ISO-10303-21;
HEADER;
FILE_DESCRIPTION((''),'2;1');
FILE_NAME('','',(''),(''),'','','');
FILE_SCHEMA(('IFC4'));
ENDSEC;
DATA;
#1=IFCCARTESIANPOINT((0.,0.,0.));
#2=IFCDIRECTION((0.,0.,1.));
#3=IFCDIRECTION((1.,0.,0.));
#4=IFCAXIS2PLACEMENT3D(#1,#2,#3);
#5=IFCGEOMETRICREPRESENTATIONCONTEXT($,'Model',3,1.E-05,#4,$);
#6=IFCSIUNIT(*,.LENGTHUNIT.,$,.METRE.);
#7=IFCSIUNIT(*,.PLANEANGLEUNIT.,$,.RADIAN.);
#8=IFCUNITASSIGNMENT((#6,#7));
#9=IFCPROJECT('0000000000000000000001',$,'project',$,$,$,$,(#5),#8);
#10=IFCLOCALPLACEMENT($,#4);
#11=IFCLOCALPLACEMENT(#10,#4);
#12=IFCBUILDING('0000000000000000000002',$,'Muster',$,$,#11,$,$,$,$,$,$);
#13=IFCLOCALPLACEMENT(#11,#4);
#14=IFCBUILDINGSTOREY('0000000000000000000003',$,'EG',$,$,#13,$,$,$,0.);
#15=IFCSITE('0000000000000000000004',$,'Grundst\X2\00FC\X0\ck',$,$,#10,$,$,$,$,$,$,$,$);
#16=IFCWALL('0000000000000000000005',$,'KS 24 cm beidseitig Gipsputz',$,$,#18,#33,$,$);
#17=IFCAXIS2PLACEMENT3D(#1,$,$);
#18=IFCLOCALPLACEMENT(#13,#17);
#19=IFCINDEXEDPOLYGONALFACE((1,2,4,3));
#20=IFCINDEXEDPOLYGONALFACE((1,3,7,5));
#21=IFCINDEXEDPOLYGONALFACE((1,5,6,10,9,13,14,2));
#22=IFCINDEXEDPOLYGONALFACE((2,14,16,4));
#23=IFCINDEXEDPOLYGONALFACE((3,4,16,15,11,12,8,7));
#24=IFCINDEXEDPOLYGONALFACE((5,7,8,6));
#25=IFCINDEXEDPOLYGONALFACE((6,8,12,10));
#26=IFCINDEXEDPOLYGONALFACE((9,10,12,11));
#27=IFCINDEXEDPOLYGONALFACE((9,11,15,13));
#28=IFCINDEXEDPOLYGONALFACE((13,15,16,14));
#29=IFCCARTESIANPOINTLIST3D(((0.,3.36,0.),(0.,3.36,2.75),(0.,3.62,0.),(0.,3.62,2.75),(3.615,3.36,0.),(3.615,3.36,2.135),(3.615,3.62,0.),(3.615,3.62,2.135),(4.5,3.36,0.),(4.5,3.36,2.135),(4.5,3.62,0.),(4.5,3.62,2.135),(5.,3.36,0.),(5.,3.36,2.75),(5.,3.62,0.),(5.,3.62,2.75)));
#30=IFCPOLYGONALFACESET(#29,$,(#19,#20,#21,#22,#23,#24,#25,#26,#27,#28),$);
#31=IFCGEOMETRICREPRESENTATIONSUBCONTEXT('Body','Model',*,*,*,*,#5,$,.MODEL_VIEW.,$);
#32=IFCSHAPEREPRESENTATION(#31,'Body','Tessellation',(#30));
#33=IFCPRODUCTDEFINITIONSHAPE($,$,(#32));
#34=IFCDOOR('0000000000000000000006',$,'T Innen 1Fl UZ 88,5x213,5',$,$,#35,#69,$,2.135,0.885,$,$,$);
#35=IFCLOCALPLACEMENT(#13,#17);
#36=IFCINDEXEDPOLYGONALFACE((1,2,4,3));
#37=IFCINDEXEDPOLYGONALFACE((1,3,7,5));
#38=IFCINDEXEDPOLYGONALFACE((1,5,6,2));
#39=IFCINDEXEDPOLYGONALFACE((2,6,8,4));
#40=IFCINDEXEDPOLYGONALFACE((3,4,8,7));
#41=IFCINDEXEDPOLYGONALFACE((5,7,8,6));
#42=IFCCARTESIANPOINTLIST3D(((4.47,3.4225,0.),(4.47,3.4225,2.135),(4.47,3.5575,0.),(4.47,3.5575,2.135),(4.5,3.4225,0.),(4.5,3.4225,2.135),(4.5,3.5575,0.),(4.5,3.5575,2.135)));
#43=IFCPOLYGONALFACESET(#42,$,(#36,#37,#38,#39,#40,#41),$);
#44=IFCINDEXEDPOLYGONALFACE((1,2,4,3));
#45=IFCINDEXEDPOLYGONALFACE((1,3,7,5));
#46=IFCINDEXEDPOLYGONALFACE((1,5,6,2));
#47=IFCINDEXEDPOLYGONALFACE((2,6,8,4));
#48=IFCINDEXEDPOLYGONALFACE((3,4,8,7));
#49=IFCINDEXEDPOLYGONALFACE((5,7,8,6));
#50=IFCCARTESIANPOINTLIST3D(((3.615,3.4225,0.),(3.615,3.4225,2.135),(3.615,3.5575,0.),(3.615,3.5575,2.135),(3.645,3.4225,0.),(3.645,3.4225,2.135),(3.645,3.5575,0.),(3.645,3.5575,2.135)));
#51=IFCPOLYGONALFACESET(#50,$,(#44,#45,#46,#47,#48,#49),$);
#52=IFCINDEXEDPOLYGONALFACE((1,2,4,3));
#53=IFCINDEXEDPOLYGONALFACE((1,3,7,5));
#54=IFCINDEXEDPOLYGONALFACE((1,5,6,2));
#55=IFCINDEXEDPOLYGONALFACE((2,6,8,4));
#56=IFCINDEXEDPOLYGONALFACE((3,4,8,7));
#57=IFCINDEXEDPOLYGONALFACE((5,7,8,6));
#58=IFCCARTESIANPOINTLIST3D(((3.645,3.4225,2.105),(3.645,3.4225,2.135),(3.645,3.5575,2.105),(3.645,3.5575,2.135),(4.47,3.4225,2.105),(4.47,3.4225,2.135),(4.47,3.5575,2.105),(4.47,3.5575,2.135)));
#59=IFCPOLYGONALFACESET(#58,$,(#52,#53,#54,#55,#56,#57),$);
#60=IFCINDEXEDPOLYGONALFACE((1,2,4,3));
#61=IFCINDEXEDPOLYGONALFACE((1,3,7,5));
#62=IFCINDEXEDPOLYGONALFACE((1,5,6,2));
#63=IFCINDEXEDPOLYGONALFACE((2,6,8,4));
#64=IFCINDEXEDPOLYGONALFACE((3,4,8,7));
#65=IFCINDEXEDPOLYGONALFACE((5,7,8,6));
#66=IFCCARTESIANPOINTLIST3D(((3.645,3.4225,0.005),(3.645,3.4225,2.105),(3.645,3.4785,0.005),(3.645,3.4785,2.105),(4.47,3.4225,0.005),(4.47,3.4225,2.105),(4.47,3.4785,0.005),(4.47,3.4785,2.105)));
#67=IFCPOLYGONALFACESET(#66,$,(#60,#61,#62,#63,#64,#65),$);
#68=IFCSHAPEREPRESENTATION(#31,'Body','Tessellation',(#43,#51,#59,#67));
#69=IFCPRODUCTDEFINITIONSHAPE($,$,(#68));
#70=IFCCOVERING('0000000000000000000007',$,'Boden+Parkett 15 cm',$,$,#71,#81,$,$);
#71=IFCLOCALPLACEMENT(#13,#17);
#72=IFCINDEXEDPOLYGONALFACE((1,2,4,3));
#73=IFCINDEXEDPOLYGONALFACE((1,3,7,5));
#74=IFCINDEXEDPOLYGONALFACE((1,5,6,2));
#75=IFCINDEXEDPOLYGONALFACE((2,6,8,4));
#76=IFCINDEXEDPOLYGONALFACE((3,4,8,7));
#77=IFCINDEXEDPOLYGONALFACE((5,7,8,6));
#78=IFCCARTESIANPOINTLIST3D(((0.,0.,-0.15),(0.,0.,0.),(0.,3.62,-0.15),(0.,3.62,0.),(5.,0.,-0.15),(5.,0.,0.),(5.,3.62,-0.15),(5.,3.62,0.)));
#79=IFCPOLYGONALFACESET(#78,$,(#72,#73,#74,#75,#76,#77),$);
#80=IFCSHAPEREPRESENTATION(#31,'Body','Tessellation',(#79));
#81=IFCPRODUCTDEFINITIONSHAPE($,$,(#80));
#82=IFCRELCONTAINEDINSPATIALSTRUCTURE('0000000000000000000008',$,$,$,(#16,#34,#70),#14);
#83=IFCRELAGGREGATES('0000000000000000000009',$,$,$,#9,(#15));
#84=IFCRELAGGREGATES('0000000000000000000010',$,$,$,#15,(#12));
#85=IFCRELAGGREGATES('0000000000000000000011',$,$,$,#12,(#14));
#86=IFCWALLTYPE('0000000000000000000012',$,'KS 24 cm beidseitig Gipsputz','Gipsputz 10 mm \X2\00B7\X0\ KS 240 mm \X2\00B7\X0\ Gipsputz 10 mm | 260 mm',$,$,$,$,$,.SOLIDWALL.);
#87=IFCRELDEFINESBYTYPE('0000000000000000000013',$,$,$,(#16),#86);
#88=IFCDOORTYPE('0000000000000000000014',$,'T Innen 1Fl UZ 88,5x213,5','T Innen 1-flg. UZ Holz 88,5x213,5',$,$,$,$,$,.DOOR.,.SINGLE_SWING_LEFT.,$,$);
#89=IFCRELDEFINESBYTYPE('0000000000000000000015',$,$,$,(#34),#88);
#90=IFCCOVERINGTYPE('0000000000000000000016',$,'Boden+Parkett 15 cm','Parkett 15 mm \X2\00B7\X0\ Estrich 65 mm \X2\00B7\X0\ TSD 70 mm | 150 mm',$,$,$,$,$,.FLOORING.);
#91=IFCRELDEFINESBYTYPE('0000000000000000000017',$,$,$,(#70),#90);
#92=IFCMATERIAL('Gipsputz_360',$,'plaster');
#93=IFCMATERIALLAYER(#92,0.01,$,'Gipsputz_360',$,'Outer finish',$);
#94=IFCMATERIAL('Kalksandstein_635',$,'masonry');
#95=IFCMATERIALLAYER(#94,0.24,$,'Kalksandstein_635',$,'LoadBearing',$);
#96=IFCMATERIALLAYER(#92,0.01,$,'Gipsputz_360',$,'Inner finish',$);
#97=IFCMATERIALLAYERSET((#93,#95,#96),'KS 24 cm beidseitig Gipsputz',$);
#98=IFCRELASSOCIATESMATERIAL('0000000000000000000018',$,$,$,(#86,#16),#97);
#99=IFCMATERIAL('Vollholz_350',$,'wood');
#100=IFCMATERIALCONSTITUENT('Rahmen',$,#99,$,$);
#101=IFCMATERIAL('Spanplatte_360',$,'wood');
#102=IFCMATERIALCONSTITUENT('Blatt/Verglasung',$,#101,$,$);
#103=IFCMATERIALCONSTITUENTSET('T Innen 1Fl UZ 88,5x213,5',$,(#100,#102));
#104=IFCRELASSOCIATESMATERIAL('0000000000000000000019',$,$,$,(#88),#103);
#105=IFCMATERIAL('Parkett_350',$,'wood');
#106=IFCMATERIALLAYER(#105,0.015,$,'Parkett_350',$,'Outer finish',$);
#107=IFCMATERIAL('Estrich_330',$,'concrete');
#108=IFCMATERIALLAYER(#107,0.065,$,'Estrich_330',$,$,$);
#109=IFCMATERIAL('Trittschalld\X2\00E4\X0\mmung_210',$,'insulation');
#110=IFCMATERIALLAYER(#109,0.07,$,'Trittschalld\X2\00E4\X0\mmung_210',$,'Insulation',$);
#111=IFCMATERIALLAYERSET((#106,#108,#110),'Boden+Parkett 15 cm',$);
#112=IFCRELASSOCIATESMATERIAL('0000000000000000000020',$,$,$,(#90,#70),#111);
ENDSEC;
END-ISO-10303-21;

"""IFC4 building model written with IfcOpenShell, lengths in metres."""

from ifc_helpers import new_model, si_unit, frame, frame_2d, origin, origin_with_axes, place, context, subcontext, project, spatial, rectangle, extrude, source, transform, mapped, material, layer, layer_set, layer_usage, constituent, constituent_set, type_object, type_shapes, element, fill, save


model = new_model("IFC4")

# Units and contexts
model_context = context("Model", 3, precision=1e-05, world=origin_with_axes())
body_context = subcontext(model_context, "Body", "Model", "MODEL_VIEW")
ifc_project = project(units=[si_unit("LENGTHUNIT", "METRE"), si_unit("PLANEANGLEUNIT", "RADIAN")], contexts=[model_context])

# Site, building, storey
site_placement = place(None, origin_with_axes())
site = spatial("IfcSite", under=ifc_project, at=site_placement, Name="Grundstück")
building_placement = place(site_placement, origin_with_axes())
building = spatial("IfcBuilding", under=site, at=building_placement, Name="Muster")
storey_placement = place(building_placement, origin_with_axes())
storey = spatial("IfcBuildingStorey", under=building, at=storey_placement, Name="EG", Elevation=0.0)

# Shared definitions
ifc_material_1 = material(Name="Kalksandstein_635", Category="masonry")
ifc_material_2 = material(Name="Gipsputz_360", Category="plaster")
ifc_material_3 = material(Name="Vollholz_350", Category="wood")

# Wall, opening, door
ifc_layer_1 = layer(ifc_material_2, 0.01, Name="Gipsputz_360", Category="Outer finish")
ifc_layer_2 = layer(ifc_material_1, 0.24, Name="Kalksandstein_635", Category="LoadBearing")
ifc_layer_3 = layer(ifc_material_2, 0.01, Name="Gipsputz_360", Category="Inner finish")
ifc_layer_set_1 = layer_set([ifc_layer_1, ifc_layer_2, ifc_layer_3], Name="KS 24 cm beidseitig Gipsputz")
ifc_layer_usage_1 = layer_usage(ifc_layer_set_1, "AXIS2", "POSITIVE", 0.0)
wall_type_1 = type_object("IfcWallType", Name="KS 24 cm beidseitig Gipsputz", Description="Gipsputz 10 mm · KS 240 mm · Gipsputz 10 mm | 260 mm", PredefinedType="SOLIDWALL", material=ifc_layer_set_1)
wall_1_placement = place(storey_placement, frame((5.0, 3.62, 0.0), z_axis=(0.0, 0.0, 1.0), x_axis=(-1.0, 0.0, 0.0)))
wall_1 = element("IfcWall", 1, at=wall_1_placement, inside=storey, type_object=wall_type_1, material=ifc_layer_usage_1, Name="KS 24 cm beidseitig Gipsputz", context=body_context, shape_type="SweptSolid", body=[
    extrude(rectangle(XDim=5.0, YDim=0.26, at=frame_2d((2.5, 0.13))), origin(), (0.0, 0.0, 1.0), 2.75),
])
opening_1_placement = place(wall_1_placement, frame((0.5, 0.0, 0.0), z_axis=(0.0, 0.0, 1.0), x_axis=(1.0, 0.0, 0.0)))
opening_1 = element("IfcOpeningElement", 2, at=opening_1_placement, cuts=wall_1, PredefinedType="OPENING", context=body_context, shape_type="SweptSolid", body=[
    extrude(rectangle(XDim=0.885, YDim=0.28, at=frame_2d((0.4425, 0.13))), origin(), (0.0, 0.0, 1.0), 2.135),
])
ifc_constituent_1 = constituent(ifc_material_3, Name="Rahmen")
ifc_material_4 = material(Name="Spanplatte_360", Category="wood")
ifc_constituent_2 = constituent(ifc_material_4, Name="Blatt/Verglasung")
ifc_constituent_set_1 = constituent_set(constituents=[ifc_constituent_1, ifc_constituent_2], Name="T Innen 1Fl UZ 88,5x213,5")
door_type = type_object("IfcDoorType", Name="T Innen 1Fl UZ 88,5x213,5", Description="T Innen 1-flg. UZ Holz 88,5x213,5", OperationType="SINGLE_SWING_LEFT", PredefinedType="DOOR", material=ifc_constituent_set_1)
shared_shape_1 = source(origin(), body_context, "Body", "SweptSolid", [
    extrude(rectangle(XDim=0.03, YDim=0.135, at=frame_2d((0.015, 0.0675))), origin(), (0.0, 0.0, 1.0), 2.135),
    extrude(rectangle(XDim=0.03, YDim=0.135, at=frame_2d((0.87, 0.0675))), origin(), (0.0, 0.0, 1.0), 2.135),
    extrude(rectangle(XDim=0.825, YDim=0.135, at=frame_2d((0.4425, 0.0675))), frame((0.0, 0.0, 2.105)), (0.0, 0.0, 1.0), 0.03),
    extrude(rectangle(XDim=0.825, YDim=0.056, at=frame_2d((0.4425, 0.107))), frame((0.0, 0.0, 0.005)), (0.0, 0.0, 1.0), 2.1),
])
type_shapes(door_type, [shared_shape_1])
door_placement = place(opening_1_placement, origin_with_axes())
door = element("IfcDoor", 3, at=door_placement, inside=storey, type_object=door_type, Name="T Innen 1Fl UZ 88,5x213,5", OverallHeight=2.135, OverallWidth=0.885, context=body_context, shape_type="MappedRepresentation", body=[
    mapped(shared_shape_1, transform((0.0, 0.0625, 0.0))),
])
fill(opening_1, door)

# Covering
ifc_material_5 = material(Name="Parkett_350", Category="wood")
ifc_layer_4 = layer(ifc_material_5, 0.015, Name="Parkett_350", Category="Outer finish")
ifc_material_6 = material(Name="Estrich_330", Category="concrete")
ifc_layer_5 = layer(ifc_material_6, 0.065, Name="Estrich_330")
ifc_material_7 = material(Name="Trittschalldämmung_210", Category="insulation")
ifc_layer_6 = layer(ifc_material_7, 0.07, Name="Trittschalldämmung_210", Category="Insulation")
ifc_layer_set_2 = layer_set([ifc_layer_4, ifc_layer_5, ifc_layer_6], Name="Boden+Parkett 15 cm")
ifc_layer_usage_2 = layer_usage(ifc_layer_set_2, "AXIS3", "NEGATIVE", 0.0)
covering_type = type_object("IfcCoveringType", Name="Boden+Parkett 15 cm", Description="Parkett 15 mm · Estrich 65 mm · TSD 70 mm | 150 mm", PredefinedType="FLOORING", material=ifc_layer_set_2)
covering_placement = place(storey_placement, origin_with_axes())
element("IfcCovering", 4, at=covering_placement, inside=storey, type_object=covering_type, material=ifc_layer_usage_2, Name="Boden+Parkett 15 cm", context=body_context, shape_type="SweptSolid", body=[
    extrude(rectangle(XDim=5.0, YDim=3.62, at=frame_2d((2.5, 1.81))), origin(), (0.0, 0.0, -1.0), 0.15),
])

save(model, "model.ifc")
